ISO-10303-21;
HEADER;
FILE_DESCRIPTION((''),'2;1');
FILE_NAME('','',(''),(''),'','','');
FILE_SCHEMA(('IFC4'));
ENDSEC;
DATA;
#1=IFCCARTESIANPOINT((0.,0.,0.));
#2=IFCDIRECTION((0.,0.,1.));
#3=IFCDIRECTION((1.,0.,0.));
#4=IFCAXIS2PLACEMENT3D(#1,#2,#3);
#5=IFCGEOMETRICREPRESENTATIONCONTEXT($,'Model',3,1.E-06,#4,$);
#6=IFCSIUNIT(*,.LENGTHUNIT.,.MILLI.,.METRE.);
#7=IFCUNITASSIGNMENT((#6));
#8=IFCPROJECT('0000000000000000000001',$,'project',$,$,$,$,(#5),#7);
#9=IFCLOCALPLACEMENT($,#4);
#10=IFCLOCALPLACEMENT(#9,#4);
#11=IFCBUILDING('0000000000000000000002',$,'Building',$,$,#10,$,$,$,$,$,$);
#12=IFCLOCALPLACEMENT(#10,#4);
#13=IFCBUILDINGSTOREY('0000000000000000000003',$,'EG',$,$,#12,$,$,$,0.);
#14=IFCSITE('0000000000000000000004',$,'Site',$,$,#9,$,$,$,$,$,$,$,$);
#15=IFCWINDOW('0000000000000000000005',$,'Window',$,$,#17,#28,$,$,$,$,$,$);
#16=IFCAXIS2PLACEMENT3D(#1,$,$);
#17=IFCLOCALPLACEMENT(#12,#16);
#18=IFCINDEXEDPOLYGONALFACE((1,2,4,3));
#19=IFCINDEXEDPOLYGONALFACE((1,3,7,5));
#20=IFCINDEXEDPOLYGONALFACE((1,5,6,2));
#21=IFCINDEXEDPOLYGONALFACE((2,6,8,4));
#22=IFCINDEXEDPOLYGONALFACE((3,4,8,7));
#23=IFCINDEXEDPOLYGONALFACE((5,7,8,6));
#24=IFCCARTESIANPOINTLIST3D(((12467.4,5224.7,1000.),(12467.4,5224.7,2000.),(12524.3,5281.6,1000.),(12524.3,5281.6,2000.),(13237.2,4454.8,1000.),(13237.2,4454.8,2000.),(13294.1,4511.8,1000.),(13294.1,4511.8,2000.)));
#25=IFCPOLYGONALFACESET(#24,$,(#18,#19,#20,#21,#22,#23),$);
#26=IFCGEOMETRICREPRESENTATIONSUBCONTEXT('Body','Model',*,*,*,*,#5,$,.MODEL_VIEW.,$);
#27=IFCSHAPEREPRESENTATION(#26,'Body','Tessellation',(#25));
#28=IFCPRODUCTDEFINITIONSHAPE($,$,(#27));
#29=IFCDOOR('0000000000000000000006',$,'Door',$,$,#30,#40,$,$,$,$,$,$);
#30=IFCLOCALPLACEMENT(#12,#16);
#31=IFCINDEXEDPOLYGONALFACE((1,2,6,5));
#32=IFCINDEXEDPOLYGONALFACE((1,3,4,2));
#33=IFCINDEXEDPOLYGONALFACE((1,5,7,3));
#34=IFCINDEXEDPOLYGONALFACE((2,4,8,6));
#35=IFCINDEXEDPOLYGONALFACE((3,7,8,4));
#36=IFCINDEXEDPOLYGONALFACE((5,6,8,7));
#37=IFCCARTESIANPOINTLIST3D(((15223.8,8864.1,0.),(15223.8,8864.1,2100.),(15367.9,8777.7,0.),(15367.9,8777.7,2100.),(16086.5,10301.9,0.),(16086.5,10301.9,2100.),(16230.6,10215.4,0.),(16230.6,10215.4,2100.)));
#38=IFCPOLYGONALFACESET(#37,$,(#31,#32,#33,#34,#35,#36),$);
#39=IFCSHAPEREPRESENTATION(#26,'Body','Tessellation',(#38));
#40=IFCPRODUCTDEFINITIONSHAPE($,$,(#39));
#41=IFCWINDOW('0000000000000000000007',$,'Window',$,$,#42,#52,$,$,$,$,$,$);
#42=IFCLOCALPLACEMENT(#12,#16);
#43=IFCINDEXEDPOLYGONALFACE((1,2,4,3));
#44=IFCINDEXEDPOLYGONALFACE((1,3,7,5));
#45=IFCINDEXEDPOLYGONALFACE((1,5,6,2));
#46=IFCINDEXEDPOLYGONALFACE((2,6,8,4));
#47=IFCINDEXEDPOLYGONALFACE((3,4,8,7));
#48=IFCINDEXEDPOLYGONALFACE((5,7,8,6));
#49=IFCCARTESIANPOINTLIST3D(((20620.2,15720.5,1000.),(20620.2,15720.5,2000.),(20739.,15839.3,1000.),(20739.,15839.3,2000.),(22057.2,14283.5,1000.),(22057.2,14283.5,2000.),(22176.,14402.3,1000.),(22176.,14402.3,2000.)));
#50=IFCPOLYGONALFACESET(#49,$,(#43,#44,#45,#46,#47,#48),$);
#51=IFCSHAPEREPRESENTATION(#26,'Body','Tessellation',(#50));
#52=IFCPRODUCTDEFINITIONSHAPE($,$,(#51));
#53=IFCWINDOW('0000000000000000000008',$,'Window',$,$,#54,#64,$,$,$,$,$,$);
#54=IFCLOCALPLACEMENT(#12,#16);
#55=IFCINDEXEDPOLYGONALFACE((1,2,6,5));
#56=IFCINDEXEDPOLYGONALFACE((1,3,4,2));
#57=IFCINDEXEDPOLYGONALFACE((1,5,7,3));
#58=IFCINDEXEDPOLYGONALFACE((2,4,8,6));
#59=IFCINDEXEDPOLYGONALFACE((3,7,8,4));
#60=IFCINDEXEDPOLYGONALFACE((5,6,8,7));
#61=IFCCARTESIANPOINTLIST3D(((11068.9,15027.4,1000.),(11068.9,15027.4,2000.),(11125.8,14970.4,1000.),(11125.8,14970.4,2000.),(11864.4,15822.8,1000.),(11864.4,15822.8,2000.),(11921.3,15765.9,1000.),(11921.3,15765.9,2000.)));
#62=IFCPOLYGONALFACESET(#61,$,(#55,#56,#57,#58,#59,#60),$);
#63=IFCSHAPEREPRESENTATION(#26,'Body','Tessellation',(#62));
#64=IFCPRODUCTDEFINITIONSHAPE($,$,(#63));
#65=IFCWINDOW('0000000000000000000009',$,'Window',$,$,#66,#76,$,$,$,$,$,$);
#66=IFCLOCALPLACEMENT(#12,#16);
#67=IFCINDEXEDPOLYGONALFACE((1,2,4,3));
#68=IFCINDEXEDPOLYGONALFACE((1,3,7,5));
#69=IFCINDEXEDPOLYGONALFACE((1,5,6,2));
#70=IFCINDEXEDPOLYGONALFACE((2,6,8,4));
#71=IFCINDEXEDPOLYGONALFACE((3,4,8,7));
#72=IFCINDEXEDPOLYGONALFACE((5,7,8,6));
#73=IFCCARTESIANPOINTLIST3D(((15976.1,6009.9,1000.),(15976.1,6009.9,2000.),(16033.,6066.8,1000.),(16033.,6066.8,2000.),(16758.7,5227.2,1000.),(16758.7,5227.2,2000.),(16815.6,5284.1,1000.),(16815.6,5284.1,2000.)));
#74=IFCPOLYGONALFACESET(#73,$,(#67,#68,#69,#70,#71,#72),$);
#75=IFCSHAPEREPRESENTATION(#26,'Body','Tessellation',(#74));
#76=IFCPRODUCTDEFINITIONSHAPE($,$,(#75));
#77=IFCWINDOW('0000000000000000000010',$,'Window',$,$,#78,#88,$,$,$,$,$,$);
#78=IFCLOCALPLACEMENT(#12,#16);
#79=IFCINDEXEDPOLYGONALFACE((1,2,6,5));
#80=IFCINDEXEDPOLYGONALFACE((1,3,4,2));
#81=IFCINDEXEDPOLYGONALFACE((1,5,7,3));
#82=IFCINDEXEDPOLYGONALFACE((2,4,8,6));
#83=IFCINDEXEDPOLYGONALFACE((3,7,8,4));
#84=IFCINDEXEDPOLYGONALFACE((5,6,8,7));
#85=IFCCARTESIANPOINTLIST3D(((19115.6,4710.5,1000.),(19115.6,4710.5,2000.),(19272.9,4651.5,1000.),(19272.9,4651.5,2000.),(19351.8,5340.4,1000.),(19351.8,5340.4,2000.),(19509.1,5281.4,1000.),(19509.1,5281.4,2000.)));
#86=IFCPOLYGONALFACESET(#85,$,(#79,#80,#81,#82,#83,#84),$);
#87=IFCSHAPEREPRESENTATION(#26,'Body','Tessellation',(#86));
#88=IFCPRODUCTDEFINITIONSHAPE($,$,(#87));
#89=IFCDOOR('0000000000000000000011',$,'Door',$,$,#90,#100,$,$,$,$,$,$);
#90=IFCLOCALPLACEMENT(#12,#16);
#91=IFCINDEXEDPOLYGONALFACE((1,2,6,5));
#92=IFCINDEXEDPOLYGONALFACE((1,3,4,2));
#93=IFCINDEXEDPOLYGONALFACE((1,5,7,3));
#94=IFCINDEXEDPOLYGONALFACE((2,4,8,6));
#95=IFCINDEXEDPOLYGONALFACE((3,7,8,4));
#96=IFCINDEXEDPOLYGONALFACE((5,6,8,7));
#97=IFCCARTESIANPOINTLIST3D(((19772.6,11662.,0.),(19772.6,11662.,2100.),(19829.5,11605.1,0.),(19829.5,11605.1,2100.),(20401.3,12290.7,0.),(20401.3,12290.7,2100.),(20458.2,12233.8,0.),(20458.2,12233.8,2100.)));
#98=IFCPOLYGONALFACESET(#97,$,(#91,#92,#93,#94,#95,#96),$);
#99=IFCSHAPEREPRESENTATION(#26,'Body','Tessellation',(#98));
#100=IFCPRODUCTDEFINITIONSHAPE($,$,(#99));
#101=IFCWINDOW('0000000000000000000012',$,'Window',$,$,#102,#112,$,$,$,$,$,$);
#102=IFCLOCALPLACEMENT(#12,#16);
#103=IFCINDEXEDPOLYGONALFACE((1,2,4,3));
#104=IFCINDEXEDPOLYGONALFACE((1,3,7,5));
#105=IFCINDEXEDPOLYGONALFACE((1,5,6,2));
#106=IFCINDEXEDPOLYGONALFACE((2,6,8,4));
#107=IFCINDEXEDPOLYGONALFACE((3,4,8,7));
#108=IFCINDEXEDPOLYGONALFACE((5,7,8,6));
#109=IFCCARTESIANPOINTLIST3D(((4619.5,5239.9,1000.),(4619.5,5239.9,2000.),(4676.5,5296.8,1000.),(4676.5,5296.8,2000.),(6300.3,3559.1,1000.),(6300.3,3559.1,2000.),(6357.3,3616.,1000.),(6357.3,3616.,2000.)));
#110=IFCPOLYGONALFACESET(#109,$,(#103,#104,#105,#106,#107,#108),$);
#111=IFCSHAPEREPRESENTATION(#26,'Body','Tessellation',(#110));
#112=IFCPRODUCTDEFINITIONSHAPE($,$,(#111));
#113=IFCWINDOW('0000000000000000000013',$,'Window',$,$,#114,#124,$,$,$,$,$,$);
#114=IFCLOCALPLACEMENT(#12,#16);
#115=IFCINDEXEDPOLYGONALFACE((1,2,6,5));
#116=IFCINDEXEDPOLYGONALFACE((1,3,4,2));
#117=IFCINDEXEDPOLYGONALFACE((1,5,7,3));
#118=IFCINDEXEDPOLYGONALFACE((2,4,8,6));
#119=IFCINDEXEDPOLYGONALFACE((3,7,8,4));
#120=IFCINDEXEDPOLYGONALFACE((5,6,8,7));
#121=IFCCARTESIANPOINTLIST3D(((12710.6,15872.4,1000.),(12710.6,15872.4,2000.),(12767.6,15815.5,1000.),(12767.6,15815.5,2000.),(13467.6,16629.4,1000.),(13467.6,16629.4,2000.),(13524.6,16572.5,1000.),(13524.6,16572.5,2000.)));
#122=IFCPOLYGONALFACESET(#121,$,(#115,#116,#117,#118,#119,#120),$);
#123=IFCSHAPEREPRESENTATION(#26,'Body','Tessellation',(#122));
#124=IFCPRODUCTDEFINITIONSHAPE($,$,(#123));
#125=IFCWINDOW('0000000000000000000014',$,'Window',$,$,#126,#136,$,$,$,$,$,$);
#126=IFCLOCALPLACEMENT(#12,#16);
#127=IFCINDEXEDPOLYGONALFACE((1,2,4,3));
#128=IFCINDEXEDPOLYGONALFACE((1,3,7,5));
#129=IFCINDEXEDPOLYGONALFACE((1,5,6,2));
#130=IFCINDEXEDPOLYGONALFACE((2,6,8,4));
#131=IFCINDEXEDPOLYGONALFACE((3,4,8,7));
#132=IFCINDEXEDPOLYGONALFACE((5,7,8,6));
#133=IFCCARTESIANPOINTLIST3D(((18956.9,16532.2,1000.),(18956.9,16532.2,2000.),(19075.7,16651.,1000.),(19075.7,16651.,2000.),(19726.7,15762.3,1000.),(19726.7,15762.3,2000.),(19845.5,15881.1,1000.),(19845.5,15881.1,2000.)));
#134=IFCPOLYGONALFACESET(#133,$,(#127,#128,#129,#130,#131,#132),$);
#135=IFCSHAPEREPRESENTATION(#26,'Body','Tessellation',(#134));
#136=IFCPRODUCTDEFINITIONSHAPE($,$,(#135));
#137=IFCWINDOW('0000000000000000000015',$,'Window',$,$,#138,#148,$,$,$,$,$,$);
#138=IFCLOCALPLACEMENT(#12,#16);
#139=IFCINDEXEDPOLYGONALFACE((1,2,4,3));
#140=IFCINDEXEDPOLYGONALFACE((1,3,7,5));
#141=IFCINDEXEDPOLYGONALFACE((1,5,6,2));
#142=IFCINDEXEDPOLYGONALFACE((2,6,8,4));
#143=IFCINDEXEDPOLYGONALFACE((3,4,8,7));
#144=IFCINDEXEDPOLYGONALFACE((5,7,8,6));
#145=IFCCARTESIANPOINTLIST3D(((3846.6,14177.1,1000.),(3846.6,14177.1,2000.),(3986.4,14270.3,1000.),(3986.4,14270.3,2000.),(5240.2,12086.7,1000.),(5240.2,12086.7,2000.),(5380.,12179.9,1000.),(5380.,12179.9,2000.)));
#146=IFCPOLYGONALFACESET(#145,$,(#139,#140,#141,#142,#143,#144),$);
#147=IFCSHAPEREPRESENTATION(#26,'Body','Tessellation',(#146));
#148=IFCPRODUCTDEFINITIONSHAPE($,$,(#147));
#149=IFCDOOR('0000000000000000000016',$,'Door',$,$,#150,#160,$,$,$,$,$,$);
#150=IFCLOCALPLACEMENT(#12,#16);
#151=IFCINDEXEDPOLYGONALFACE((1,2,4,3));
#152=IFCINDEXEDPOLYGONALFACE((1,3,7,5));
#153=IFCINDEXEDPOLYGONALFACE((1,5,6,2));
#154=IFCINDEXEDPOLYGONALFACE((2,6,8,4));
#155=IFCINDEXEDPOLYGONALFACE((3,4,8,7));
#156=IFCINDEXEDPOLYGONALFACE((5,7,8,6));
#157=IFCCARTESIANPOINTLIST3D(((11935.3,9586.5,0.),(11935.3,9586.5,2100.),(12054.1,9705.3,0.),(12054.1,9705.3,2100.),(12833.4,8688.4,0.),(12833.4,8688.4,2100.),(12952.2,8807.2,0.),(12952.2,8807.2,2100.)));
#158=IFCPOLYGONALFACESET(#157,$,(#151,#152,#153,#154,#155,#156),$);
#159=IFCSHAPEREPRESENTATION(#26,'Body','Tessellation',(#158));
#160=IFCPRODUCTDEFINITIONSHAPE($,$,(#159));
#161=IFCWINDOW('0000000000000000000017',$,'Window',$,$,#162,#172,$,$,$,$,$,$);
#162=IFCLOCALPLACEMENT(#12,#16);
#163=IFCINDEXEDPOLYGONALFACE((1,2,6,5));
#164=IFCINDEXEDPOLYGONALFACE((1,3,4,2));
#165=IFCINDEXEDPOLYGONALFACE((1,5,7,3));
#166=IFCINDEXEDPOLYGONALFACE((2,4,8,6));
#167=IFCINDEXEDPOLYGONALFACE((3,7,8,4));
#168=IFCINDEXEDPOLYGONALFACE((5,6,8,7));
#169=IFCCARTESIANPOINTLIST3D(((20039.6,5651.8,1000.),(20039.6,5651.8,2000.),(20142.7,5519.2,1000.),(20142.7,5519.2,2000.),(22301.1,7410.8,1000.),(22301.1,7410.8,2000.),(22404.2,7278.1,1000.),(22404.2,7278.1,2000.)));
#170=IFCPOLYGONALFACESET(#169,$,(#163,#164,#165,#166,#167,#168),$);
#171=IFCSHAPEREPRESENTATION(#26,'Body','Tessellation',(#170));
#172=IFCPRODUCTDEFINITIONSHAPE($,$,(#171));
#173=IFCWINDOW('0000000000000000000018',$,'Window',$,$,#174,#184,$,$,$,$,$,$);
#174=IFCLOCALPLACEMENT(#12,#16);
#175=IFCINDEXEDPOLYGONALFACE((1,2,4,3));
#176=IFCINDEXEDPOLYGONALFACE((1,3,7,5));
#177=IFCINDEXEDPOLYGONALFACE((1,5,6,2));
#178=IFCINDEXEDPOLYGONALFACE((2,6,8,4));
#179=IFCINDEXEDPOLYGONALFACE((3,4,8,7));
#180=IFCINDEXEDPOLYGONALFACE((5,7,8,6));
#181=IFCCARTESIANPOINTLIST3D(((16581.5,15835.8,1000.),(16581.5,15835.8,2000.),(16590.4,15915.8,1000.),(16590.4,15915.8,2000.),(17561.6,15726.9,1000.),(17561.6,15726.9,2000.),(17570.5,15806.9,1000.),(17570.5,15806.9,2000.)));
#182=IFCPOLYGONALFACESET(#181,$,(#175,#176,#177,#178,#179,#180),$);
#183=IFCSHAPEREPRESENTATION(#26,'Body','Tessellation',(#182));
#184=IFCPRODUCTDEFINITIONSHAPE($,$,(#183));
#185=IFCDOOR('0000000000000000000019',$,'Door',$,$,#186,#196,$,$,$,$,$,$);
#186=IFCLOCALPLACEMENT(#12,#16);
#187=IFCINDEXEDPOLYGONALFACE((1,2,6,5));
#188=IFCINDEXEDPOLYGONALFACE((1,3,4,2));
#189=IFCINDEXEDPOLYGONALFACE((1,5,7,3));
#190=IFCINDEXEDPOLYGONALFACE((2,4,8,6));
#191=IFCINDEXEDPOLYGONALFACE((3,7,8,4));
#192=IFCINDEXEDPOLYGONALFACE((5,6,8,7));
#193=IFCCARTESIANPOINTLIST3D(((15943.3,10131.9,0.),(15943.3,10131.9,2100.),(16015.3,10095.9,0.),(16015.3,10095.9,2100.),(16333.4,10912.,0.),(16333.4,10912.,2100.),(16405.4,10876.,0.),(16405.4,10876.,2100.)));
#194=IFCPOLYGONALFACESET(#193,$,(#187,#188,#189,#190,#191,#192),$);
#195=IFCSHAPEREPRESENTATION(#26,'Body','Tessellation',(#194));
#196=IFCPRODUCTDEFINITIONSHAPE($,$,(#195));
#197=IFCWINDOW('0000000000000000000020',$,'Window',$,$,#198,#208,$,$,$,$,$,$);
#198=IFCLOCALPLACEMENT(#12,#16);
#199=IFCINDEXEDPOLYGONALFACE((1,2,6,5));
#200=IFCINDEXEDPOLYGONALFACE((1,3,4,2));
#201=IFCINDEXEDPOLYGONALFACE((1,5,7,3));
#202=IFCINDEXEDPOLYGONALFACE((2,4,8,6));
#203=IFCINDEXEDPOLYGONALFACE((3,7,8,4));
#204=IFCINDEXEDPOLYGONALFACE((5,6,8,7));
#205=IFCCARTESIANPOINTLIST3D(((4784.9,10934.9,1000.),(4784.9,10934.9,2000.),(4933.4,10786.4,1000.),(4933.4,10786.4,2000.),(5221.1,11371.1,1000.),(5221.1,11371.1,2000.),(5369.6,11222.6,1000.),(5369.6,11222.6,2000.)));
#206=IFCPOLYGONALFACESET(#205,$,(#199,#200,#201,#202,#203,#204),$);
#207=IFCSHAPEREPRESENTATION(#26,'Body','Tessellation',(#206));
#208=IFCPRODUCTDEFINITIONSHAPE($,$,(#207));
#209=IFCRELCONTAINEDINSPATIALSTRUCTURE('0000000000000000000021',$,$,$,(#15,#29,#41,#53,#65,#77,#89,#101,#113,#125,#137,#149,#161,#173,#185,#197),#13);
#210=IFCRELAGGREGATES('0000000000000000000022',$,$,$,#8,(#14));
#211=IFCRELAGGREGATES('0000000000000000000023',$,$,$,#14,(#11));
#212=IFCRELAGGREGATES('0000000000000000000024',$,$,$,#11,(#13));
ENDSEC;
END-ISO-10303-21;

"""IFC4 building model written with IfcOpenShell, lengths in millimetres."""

from ifc_helpers import new_model, si_unit, frame, origin_with_axes, place, context, subcontext, project, spatial, rectangle, extrude, element, save


model = new_model("IFC4")

# Units and contexts
model_context = context("Model", 3, precision=1e-06, world=origin_with_axes())
body_context = subcontext(model_context, "Body", "Model", "MODEL_VIEW")
ifc_project = project(units=[si_unit("LENGTHUNIT", "METRE", prefix="MILLI")], contexts=[model_context])

# Site, building, storey
site_placement = place(None, origin_with_axes())
site = spatial("IfcSite", under=ifc_project, at=site_placement, Name="Site")
building_placement = place(site_placement, origin_with_axes())
building = spatial("IfcBuilding", under=site, at=building_placement, Name="Building")
storey_placement = place(building_placement, origin_with_axes())
storey = spatial("IfcBuildingStorey", under=building, at=storey_placement, Name="EG", Elevation=0.0)

# Window
window_1_placement = place(storey_placement, origin_with_axes())
element("IfcWindow", 1, at=window_1_placement, inside=storey, Name="Window", context=body_context, shape_type="SweptSolid", body=[
    extrude(rectangle(XDim=1088.7, YDim=80.5), frame((12880.8, 4868.2, 1000.0), z_axis=(0.0, 0.0, 1.0), x_axis=(0.707107, -0.707107, 0.0)), (0.0, 0.0, 1.0), 1000.0),
])

# Door
door_1_placement = place(storey_placement, origin_with_axes())
element("IfcDoor", 2, at=door_1_placement, inside=storey, Name="Door", context=body_context, shape_type="SweptSolid", body=[
    extrude(rectangle(XDim=1676.7, YDim=168.0), frame((15727.2, 9539.8, 0.0), z_axis=(0.0, 0.0, 1.0), x_axis=(0.514496, 0.857493, 0.0)), (0.0, 0.0, 1.0), 2100.0),
])

# Windows
window_2_placement = place(storey_placement, origin_with_axes())
element("IfcWindow", 3, at=window_2_placement, inside=storey, Name="Window", context=body_context, shape_type="SweptSolid", body=[
    extrude(rectangle(XDim=2032.3, YDim=168.0), frame((21398.1, 15061.4, 1000.0), z_axis=(0.0, 0.0, 1.0), x_axis=(0.707107, -0.707107, 0.0)), (0.0, 0.0, 1.0), 1000.0),
])
window_3_placement = place(storey_placement, origin_with_axes())
element("IfcWindow", 4, at=window_3_placement, inside=storey, Name="Window", context=body_context, shape_type="SweptSolid", body=[
    extrude(rectangle(XDim=1125.0, YDim=80.5), frame((11495.1, 15396.6, 1000.0), z_axis=(0.0, 0.0, 1.0), x_axis=(-0.707107, -0.707107, 0.0)), (0.0, 0.0, 1.0), 1000.0),
])
window_4_placement = place(storey_placement, origin_with_axes())
element("IfcWindow", 5, at=window_4_placement, inside=storey, Name="Window", context=body_context, shape_type="SweptSolid", body=[
    extrude(rectangle(XDim=1106.9, YDim=80.5), frame((16395.9, 5647.0, 1000.0), z_axis=(0.0, 0.0, 1.0), x_axis=(-0.707107, 0.707107, 0.0)), (0.0, 0.0, 1.0), 1000.0),
])
window_5_placement = place(storey_placement, origin_with_axes())
element("IfcWindow", 6, at=window_5_placement, inside=storey, Name="Window", context=body_context, shape_type="SweptSolid", body=[
    extrude(rectangle(XDim=672.8, YDim=168.0), frame((19312.4, 4996.0, 1000.0), z_axis=(0.0, 0.0, 1.0), x_axis=(0.351123, 0.936329, 0.0)), (0.0, 0.0, 1.0), 1000.0),
])

# Door
door_2_placement = place(storey_placement, origin_with_axes())
element("IfcDoor", 7, at=door_2_placement, inside=storey, Name="Door", context=body_context, shape_type="SweptSolid", body=[
    extrude(rectangle(XDim=889.1, YDim=80.5), frame((20115.4, 11947.9, 0.0), z_axis=(0.0, 0.0, 1.0), x_axis=(0.707107, 0.707107, 0.0)), (0.0, 0.0, 1.0), 2100.0),
])

# Windows
window_6_placement = place(storey_placement, origin_with_axes())
element("IfcWindow", 8, at=window_6_placement, inside=storey, Name="Window", context=body_context, shape_type="SweptSolid", body=[
    extrude(rectangle(XDim=2377.0, YDim=80.5), frame((5488.4, 4427.9, 1000.0), z_axis=(0.0, 0.0, 1.0), x_axis=(0.707107, -0.707107, 0.0)), (0.0, 0.0, 1.0), 1000.0),
])
window_7_placement = place(storey_placement, origin_with_axes())
element("IfcWindow", 9, at=window_7_placement, inside=storey, Name="Window", context=body_context, shape_type="SweptSolid", body=[
    extrude(rectangle(XDim=1070.6, YDim=80.5), frame((13117.6, 16222.4, 1000.0), z_axis=(0.0, 0.0, 1.0), x_axis=(0.707107, 0.707107, 0.0)), (0.0, 0.0, 1.0), 1000.0),
])
window_8_placement = place(storey_placement, origin_with_axes())
element("IfcWindow", 10, at=window_8_placement, inside=storey, Name="Window", context=body_context, shape_type="SweptSolid", body=[
    extrude(rectangle(XDim=1088.7, YDim=168.0), frame((19401.2, 16206.7, 1000.0), z_axis=(0.0, 0.0, 1.0), x_axis=(-0.707107, 0.707107, 0.0)), (0.0, 0.0, 1.0), 1000.0),
])
window_9_placement = place(storey_placement, origin_with_axes())
element("IfcWindow", 11, at=window_9_placement, inside=storey, Name="Window", context=body_context, shape_type="SweptSolid", body=[
    extrude(rectangle(XDim=2512.3, YDim=168.0), frame((4613.3, 13178.5, 1000.0), z_axis=(0.0, 0.0, 1.0), x_axis=(-0.5547, 0.83205, 0.0)), (0.0, 0.0, 1.0), 1000.0),
])

# Door
door_3_placement = place(storey_placement, origin_with_axes())
element("IfcDoor", 12, at=door_3_placement, inside=storey, Name="Door", context=body_context, shape_type="SweptSolid", body=[
    extrude(rectangle(XDim=1270.2, YDim=168.0), frame((12443.8, 9196.9, 0.0), z_axis=(0.0, 0.0, 1.0), x_axis=(0.707107, -0.707107, 0.0)), (0.0, 0.0, 1.0), 2100.0),
])

# Windows
window_10_placement = place(storey_placement, origin_with_axes())
element("IfcWindow", 13, at=window_10_placement, inside=storey, Name="Window", context=body_context, shape_type="SweptSolid", body=[
    extrude(rectangle(XDim=2865.0, YDim=168.0), frame((21221.9, 6465.0, 1000.0), z_axis=(0.0, 0.0, 1.0), x_axis=(-0.789352, -0.613941, 0.0)), (0.0, 0.0, 1.0), 1000.0),
])
window_11_placement = place(storey_placement, origin_with_axes())
element("IfcWindow", 14, at=window_11_placement, inside=storey, Name="Window", context=body_context, shape_type="SweptSolid", body=[
    extrude(rectangle(XDim=986.2, YDim=80.5), frame((17076.0, 15821.4, 1000.0), z_axis=(0.0, 0.0, 1.0), x_axis=(0.993884, -0.110432, 0.0)), (0.0, 0.0, 1.0), 1000.0),
])

# Door
door_4_placement = place(storey_placement, origin_with_axes())
element("IfcDoor", 15, at=door_4_placement, inside=storey, Name="Door", context=body_context, shape_type="SweptSolid", body=[
    extrude(rectangle(XDim=872.2, YDim=80.5), frame((16174.4, 10504.0, 0.0), z_axis=(0.0, 0.0, 1.0), x_axis=(0.447214, 0.894427, 0.0)), (0.0, 0.0, 1.0), 2100.0),
])

# Window
window_12_placement = place(storey_placement, origin_with_axes())
element("IfcWindow", 16, at=window_12_placement, inside=storey, Name="Window", context=body_context, shape_type="SweptSolid", body=[
    extrude(rectangle(XDim=616.9, YDim=210.0), frame((5077.3, 11078.7, 1000.0), z_axis=(0.0, 0.0, 1.0), x_axis=(-0.707107, -0.707107, 0.0)), (0.0, 0.0, 1.0), 1000.0),
])

save(model, "model.ifc")
